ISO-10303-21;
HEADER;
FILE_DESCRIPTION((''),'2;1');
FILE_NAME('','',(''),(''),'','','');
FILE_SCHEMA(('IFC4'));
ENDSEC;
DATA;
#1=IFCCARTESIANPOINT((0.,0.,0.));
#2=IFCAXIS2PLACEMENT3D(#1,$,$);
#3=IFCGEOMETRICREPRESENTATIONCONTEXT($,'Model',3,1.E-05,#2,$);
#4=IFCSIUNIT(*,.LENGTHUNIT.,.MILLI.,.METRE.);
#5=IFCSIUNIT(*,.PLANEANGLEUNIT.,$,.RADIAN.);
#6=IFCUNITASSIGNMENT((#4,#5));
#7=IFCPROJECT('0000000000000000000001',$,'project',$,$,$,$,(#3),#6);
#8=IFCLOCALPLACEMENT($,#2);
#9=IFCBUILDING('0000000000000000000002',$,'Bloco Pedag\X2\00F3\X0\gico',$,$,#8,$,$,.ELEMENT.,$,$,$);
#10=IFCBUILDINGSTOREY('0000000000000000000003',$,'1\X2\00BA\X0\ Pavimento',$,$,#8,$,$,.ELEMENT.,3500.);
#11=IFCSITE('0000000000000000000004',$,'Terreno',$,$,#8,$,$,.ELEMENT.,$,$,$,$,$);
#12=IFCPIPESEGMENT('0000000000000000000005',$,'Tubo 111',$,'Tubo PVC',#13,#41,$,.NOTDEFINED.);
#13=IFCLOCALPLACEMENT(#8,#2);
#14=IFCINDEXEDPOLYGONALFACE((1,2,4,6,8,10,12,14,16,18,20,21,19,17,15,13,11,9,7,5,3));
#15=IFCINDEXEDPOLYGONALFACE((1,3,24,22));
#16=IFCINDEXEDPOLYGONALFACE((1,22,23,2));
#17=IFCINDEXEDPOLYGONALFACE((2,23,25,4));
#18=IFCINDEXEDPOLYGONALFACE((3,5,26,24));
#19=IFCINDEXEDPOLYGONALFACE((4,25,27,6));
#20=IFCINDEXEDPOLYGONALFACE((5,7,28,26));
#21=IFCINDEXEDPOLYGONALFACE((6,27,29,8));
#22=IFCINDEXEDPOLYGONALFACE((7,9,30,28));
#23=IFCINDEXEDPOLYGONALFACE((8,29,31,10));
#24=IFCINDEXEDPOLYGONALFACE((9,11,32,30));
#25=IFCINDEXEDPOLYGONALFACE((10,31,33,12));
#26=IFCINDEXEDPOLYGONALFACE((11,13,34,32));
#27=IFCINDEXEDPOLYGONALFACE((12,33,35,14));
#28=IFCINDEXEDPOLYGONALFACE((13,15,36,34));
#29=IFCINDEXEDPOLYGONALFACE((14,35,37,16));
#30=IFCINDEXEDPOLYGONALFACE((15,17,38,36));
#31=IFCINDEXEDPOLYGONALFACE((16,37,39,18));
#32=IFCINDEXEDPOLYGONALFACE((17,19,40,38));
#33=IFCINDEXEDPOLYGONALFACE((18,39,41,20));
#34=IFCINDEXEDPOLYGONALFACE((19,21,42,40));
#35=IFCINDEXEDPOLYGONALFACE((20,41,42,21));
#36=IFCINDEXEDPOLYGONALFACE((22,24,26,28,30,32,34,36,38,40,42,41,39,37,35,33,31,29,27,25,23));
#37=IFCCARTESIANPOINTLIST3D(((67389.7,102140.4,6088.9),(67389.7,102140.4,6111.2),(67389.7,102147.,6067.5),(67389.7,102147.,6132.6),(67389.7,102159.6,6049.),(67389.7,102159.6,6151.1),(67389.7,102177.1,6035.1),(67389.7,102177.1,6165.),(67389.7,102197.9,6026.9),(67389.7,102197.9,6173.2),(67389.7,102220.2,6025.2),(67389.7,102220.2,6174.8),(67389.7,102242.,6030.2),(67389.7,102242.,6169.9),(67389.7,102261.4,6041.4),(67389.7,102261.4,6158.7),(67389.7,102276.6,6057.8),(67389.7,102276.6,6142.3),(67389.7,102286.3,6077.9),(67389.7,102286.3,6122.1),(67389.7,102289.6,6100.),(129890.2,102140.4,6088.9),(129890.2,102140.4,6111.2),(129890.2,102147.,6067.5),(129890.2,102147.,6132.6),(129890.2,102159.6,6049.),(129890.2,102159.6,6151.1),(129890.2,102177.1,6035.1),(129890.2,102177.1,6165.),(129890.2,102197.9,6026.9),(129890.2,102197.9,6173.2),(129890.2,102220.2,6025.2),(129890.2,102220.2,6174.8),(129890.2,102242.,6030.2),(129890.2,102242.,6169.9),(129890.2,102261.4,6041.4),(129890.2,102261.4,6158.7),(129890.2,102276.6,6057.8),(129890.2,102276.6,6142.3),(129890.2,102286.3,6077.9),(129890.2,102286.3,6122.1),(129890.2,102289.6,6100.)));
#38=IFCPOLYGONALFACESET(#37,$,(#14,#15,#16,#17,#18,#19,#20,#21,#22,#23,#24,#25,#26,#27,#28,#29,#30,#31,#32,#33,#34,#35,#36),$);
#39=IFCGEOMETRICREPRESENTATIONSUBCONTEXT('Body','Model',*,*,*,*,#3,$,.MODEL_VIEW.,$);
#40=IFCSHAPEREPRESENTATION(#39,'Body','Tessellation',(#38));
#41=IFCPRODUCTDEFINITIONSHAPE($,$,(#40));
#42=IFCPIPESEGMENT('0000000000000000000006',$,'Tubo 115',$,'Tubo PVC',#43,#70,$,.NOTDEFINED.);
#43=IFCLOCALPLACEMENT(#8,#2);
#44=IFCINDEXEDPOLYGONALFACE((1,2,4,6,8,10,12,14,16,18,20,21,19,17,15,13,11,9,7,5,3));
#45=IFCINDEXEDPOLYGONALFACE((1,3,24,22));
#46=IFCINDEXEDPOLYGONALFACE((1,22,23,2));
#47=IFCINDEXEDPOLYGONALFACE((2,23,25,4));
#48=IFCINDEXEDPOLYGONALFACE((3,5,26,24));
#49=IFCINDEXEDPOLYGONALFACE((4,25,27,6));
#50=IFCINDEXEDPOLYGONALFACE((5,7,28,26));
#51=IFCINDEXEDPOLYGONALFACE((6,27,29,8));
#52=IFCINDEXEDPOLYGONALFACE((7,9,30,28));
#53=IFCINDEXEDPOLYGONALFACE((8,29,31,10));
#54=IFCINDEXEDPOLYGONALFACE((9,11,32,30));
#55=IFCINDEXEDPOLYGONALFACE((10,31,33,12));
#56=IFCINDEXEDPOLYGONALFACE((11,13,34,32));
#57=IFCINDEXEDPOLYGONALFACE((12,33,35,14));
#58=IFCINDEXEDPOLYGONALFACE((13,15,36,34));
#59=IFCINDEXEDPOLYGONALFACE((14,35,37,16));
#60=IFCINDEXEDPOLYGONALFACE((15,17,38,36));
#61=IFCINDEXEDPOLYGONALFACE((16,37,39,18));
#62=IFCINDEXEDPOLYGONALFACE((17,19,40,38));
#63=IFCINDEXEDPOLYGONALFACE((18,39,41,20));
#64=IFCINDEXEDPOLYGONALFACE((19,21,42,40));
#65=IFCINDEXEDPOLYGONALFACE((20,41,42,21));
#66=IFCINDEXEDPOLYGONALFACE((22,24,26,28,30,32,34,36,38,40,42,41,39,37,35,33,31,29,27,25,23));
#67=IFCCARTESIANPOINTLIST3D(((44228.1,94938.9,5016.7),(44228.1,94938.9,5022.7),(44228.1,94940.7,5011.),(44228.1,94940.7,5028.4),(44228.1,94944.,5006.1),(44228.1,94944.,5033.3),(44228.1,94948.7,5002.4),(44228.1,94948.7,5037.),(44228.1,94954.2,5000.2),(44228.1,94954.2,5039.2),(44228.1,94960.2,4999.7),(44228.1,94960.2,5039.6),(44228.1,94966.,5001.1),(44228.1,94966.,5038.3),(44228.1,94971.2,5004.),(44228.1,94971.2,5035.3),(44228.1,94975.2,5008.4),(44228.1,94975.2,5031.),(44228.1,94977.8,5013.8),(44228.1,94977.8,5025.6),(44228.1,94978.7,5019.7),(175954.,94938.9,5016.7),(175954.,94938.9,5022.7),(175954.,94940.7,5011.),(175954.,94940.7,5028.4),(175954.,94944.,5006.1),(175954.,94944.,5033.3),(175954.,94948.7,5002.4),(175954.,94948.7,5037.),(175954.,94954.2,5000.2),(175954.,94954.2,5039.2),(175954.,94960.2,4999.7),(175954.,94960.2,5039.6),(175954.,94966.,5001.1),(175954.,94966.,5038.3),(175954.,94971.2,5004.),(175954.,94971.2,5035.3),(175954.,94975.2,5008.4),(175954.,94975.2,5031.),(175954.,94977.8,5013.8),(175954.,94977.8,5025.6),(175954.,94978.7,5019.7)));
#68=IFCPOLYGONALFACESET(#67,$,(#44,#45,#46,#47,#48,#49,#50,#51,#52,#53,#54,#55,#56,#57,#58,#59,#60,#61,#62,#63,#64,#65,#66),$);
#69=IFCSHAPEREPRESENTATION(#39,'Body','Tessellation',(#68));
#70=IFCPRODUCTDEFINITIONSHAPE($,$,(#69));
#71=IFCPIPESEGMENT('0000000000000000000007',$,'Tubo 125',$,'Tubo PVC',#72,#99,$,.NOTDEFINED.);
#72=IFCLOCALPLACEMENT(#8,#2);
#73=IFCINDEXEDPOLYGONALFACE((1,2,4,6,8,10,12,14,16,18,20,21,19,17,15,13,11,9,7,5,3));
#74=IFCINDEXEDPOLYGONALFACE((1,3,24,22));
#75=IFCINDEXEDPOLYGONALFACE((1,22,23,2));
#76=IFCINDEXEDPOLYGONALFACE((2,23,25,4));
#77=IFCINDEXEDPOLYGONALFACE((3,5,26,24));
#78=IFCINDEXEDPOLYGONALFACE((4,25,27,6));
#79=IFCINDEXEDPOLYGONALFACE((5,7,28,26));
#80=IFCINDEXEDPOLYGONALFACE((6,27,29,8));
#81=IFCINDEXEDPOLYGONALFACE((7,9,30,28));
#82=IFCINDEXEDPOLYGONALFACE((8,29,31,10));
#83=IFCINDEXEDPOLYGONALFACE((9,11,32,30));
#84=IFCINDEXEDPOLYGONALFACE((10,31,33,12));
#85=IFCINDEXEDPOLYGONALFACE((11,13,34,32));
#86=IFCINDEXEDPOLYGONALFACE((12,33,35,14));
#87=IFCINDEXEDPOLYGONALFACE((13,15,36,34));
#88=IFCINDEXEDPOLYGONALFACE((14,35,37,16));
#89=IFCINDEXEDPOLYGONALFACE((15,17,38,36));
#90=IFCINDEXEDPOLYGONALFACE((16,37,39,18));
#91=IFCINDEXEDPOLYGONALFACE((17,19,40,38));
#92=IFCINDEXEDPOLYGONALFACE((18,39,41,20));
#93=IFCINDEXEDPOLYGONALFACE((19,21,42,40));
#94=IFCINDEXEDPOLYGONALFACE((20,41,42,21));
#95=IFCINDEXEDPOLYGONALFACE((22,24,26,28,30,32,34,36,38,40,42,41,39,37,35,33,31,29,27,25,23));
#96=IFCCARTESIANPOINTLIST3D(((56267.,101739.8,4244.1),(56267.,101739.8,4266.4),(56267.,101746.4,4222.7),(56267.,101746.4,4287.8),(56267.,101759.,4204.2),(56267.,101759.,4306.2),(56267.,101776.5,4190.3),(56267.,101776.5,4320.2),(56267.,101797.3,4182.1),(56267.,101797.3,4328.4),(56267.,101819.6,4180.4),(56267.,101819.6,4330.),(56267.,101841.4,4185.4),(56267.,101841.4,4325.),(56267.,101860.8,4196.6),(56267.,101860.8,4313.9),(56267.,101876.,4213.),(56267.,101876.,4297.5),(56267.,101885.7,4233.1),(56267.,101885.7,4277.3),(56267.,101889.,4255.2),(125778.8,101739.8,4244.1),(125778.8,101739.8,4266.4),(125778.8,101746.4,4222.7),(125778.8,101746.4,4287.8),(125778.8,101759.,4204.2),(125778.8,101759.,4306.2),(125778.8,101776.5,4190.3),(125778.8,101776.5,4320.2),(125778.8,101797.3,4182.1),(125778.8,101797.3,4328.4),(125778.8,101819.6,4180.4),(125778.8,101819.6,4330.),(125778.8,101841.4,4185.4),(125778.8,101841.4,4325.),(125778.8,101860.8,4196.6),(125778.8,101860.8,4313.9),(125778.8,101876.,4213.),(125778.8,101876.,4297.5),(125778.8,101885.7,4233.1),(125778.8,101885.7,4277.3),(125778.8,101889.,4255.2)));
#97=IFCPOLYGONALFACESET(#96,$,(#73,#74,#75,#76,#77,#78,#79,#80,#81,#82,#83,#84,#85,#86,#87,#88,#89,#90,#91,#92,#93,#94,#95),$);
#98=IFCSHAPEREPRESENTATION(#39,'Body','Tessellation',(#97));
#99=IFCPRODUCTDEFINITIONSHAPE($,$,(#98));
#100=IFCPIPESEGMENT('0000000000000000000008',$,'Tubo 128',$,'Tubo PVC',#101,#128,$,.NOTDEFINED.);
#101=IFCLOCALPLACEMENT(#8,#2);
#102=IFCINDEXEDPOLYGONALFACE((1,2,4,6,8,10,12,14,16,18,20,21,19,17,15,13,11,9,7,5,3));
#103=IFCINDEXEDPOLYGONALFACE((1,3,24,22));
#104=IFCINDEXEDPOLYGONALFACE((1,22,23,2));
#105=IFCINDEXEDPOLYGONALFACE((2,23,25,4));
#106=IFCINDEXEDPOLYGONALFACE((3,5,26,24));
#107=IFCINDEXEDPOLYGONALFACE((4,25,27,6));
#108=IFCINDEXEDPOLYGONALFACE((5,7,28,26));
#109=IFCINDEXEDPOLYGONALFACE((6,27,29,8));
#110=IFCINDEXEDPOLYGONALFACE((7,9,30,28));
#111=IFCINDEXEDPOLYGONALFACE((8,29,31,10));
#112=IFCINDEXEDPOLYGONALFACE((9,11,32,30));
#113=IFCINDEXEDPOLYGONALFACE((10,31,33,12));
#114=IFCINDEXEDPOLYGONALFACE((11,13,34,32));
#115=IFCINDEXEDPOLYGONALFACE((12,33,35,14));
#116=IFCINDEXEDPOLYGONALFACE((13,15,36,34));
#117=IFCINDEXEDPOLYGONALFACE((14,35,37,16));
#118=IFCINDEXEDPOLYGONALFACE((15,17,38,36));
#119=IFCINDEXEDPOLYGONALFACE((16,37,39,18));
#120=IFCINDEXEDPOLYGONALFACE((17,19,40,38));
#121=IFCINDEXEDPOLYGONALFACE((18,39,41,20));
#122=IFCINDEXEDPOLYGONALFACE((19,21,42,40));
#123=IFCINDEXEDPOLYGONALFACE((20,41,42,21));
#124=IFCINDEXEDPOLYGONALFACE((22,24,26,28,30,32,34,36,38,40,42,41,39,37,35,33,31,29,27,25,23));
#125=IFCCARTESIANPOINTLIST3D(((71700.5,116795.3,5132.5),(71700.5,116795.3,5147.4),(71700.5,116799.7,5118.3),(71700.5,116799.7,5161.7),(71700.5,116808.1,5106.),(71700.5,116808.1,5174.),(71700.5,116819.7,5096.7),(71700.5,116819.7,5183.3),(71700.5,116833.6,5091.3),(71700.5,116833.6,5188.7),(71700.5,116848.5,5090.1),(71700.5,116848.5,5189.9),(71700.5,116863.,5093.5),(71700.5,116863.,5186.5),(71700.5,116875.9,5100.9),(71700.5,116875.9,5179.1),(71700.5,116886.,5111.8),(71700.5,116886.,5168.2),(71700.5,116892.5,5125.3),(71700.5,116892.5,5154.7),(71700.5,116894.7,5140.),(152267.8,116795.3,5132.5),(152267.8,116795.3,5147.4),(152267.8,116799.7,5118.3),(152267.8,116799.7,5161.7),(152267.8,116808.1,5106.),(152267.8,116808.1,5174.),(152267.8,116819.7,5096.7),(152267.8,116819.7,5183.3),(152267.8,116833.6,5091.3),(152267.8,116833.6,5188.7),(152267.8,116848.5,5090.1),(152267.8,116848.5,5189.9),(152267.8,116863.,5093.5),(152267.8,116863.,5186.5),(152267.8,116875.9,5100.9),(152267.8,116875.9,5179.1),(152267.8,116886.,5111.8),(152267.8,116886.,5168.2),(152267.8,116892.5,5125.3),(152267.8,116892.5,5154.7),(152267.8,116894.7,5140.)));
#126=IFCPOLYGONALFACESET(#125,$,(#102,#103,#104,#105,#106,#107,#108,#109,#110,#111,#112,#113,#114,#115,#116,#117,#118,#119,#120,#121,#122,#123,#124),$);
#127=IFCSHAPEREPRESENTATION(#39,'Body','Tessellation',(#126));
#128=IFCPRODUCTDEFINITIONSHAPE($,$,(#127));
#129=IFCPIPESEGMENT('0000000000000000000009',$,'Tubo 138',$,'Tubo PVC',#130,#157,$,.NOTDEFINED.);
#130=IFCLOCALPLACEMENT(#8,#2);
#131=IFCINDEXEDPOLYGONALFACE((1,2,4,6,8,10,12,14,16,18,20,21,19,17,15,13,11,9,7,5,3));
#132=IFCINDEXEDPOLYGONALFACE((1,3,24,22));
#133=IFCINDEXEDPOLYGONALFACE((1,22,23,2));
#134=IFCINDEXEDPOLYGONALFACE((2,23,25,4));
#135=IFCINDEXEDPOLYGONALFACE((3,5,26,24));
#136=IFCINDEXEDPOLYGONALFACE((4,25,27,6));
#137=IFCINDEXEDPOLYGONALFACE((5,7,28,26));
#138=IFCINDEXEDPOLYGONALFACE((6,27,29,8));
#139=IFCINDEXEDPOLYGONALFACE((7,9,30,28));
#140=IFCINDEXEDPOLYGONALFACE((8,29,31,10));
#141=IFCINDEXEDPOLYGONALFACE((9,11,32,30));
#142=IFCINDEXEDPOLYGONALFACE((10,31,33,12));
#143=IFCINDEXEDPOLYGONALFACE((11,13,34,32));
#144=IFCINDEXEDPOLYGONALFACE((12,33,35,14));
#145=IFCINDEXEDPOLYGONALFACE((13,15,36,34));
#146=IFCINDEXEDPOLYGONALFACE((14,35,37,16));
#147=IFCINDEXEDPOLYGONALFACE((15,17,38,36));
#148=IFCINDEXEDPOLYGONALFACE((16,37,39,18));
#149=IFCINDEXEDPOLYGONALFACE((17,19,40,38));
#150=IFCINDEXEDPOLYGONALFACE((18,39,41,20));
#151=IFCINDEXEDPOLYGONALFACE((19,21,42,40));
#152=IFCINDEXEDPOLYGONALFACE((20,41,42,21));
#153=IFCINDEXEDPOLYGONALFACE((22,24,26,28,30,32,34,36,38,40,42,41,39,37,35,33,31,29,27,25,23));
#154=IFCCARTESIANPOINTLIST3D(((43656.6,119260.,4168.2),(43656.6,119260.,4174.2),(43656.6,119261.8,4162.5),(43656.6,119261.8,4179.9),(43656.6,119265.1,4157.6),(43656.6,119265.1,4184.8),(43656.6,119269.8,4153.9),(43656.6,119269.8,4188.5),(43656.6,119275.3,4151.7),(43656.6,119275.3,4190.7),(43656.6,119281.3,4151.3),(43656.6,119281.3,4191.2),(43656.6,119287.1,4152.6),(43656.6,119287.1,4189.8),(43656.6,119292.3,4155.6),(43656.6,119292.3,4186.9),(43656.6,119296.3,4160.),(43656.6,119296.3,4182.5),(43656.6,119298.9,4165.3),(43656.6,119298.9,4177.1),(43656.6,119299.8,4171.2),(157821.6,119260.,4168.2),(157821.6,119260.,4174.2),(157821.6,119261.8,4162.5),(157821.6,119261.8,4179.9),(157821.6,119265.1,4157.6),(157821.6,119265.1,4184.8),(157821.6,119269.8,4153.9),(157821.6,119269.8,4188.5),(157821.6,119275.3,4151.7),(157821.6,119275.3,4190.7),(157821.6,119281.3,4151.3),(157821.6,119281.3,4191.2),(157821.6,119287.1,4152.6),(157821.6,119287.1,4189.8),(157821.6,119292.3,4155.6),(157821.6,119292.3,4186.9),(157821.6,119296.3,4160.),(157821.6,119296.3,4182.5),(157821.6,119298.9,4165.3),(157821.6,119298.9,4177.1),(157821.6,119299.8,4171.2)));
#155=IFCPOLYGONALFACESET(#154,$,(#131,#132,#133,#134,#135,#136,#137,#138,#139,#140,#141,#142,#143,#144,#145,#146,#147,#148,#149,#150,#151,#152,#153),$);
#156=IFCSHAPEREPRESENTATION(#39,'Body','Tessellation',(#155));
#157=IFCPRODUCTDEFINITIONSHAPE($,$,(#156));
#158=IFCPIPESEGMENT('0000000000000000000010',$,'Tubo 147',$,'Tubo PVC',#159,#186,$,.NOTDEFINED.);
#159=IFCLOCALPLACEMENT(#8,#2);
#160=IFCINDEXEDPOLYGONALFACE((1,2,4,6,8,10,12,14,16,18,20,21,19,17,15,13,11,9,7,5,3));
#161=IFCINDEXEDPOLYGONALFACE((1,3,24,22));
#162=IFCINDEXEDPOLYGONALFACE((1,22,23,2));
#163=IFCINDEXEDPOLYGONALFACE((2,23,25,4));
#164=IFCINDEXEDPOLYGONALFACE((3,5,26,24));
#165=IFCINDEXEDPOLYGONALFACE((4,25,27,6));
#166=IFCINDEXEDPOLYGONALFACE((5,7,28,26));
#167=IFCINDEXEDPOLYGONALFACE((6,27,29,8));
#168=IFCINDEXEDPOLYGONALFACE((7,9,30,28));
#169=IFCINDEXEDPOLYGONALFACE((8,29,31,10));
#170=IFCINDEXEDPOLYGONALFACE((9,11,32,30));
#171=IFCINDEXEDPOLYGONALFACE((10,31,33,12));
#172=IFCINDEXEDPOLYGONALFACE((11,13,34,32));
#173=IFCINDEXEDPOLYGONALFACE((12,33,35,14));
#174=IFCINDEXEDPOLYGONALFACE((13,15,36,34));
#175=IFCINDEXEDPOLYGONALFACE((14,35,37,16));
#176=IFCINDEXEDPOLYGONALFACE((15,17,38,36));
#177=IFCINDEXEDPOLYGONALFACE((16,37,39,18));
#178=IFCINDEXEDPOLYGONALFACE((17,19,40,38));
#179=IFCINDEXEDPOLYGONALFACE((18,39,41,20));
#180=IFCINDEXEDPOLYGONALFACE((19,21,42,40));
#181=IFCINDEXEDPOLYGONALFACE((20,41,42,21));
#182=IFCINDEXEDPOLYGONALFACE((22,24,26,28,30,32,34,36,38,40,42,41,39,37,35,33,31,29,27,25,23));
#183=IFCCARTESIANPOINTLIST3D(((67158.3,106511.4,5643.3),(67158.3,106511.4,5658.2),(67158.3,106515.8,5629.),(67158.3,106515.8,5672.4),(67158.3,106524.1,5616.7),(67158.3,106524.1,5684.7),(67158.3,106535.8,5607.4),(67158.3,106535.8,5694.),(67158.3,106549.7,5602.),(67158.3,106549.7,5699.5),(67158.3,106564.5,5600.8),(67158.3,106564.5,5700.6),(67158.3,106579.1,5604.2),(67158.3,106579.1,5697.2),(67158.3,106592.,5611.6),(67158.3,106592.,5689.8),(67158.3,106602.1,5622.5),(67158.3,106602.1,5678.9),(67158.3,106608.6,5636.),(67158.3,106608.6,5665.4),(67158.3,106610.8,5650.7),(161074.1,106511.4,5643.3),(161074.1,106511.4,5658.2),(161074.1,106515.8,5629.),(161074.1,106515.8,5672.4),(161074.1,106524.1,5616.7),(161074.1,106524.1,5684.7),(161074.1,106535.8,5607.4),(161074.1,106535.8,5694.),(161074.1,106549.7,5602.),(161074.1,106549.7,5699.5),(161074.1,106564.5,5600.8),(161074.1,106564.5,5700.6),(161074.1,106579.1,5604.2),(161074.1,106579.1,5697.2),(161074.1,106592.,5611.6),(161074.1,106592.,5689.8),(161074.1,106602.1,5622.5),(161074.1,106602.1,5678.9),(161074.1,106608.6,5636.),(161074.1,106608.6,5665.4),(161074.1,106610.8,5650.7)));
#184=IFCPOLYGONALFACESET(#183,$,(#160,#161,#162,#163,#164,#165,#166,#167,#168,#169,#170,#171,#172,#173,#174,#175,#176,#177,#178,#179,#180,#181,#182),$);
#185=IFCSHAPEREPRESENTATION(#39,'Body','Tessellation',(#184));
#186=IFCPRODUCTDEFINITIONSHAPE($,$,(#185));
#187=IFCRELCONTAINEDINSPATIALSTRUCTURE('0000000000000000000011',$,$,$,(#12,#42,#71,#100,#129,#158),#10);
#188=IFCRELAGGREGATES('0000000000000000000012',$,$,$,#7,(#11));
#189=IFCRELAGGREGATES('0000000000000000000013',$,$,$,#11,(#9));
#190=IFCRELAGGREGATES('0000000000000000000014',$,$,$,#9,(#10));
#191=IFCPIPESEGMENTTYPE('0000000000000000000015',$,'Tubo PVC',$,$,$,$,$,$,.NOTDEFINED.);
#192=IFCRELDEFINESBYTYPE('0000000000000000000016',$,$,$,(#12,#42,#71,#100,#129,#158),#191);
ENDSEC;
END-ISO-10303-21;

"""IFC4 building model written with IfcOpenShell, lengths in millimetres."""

from ifc_helpers import new_model, si_unit, frame, origin, origin_2d, place, context, subcontext, project, spatial, circle, extrude, type_object, element, save


model = new_model("IFC4")

# Units and contexts
model_context = context("Model", 3, precision=1e-05, world=origin())
body_context = subcontext(model_context, "Body", "Model", "MODEL_VIEW")
ifc_project = project(units=[si_unit("LENGTHUNIT", "METRE", prefix="MILLI"), si_unit("PLANEANGLEUNIT", "RADIAN")], contexts=[model_context])

# Site, building, storey
placement = place(None, origin())
site = spatial("IfcSite", under=ifc_project, at=placement, Name="Terreno", CompositionType="ELEMENT")
building = spatial("IfcBuilding", under=site, at=placement, Name="Bloco Pedagógico", CompositionType="ELEMENT")
storey = spatial("IfcBuildingStorey", under=building, at=placement, Name="1º Pavimento", CompositionType="ELEMENT", Elevation=3500.0)

# Pipe segments
pipe_segment_type = type_object("IfcPipeSegmentType", Name="Tubo PVC", PredefinedType="NOTDEFINED")
pipe_segment_1_placement = place(None, frame((67389.7, 102214.6, 6100.0), z_axis=(1.0, 0.0, 0.0), x_axis=(0.0, 1.0, 0.0)))
element("IfcPipeSegment", 1, at=pipe_segment_1_placement, inside=storey, type_object=pipe_segment_type, Name="Tubo 111", ObjectType="Tubo PVC", PredefinedType="NOTDEFINED", context=body_context, shape_type="SweptSolid", body=[
    extrude(circle(Radius=75.0, at=origin_2d()), None, (0.0, 0.0, 1.0), 62500.5),
])
pipe_segment_2_placement = place(None, frame((44228.1, 94958.7, 5019.7), z_axis=(1.0, 0.0, 0.0), x_axis=(0.0, 1.0, 0.0)))
element("IfcPipeSegment", 2, at=pipe_segment_2_placement, inside=storey, type_object=pipe_segment_type, Name="Tubo 115", ObjectType="Tubo PVC", PredefinedType="NOTDEFINED", context=body_context, shape_type="SweptSolid", body=[
    extrude(circle(Radius=20.0, at=origin_2d()), None, (0.0, 0.0, 1.0), 131725.9),
])
pipe_segment_3_placement = place(None, frame((56267.0, 101814.0, 4255.2), z_axis=(1.0, 0.0, 0.0), x_axis=(0.0, 1.0, 0.0)))
element("IfcPipeSegment", 3, at=pipe_segment_3_placement, inside=storey, type_object=pipe_segment_type, Name="Tubo 125", ObjectType="Tubo PVC", PredefinedType="NOTDEFINED", context=body_context, shape_type="SweptSolid", body=[
    extrude(circle(Radius=75.0, at=origin_2d()), None, (0.0, 0.0, 1.0), 69511.8),
])
pipe_segment_4_placement = place(None, frame((71700.5, 116844.7, 5140.0), z_axis=(1.0, 0.0, 0.0), x_axis=(0.0, 1.0, 0.0)))
element("IfcPipeSegment", 4, at=pipe_segment_4_placement, inside=storey, type_object=pipe_segment_type, Name="Tubo 128", ObjectType="Tubo PVC", PredefinedType="NOTDEFINED", context=body_context, shape_type="SweptSolid", body=[
    extrude(circle(Radius=50.0, at=origin_2d()), None, (0.0, 0.0, 1.0), 80567.3),
])
pipe_segment_5_placement = place(None, frame((43656.6, 119279.8, 4171.2), z_axis=(1.0, 0.0, 0.0), x_axis=(0.0, 1.0, 0.0)))
element("IfcPipeSegment", 5, at=pipe_segment_5_placement, inside=storey, type_object=pipe_segment_type, Name="Tubo 138", ObjectType="Tubo PVC", PredefinedType="NOTDEFINED", context=body_context, shape_type="SweptSolid", body=[
    extrude(circle(Radius=20.0, at=origin_2d()), None, (0.0, 0.0, 1.0), 114165.0),
])
pipe_segment_6_placement = place(None, frame((67158.3, 106560.8, 5650.7), z_axis=(1.0, 0.0, 0.0), x_axis=(0.0, 1.0, 0.0)))
element("IfcPipeSegment", 6, at=pipe_segment_6_placement, inside=storey, type_object=pipe_segment_type, Name="Tubo 147", ObjectType="Tubo PVC", PredefinedType="NOTDEFINED", context=body_context, shape_type="SweptSolid", body=[
    extrude(circle(Radius=50.0, at=origin_2d()), None, (0.0, 0.0, 1.0), 93915.7),
])

save(model, "model.ifc")
